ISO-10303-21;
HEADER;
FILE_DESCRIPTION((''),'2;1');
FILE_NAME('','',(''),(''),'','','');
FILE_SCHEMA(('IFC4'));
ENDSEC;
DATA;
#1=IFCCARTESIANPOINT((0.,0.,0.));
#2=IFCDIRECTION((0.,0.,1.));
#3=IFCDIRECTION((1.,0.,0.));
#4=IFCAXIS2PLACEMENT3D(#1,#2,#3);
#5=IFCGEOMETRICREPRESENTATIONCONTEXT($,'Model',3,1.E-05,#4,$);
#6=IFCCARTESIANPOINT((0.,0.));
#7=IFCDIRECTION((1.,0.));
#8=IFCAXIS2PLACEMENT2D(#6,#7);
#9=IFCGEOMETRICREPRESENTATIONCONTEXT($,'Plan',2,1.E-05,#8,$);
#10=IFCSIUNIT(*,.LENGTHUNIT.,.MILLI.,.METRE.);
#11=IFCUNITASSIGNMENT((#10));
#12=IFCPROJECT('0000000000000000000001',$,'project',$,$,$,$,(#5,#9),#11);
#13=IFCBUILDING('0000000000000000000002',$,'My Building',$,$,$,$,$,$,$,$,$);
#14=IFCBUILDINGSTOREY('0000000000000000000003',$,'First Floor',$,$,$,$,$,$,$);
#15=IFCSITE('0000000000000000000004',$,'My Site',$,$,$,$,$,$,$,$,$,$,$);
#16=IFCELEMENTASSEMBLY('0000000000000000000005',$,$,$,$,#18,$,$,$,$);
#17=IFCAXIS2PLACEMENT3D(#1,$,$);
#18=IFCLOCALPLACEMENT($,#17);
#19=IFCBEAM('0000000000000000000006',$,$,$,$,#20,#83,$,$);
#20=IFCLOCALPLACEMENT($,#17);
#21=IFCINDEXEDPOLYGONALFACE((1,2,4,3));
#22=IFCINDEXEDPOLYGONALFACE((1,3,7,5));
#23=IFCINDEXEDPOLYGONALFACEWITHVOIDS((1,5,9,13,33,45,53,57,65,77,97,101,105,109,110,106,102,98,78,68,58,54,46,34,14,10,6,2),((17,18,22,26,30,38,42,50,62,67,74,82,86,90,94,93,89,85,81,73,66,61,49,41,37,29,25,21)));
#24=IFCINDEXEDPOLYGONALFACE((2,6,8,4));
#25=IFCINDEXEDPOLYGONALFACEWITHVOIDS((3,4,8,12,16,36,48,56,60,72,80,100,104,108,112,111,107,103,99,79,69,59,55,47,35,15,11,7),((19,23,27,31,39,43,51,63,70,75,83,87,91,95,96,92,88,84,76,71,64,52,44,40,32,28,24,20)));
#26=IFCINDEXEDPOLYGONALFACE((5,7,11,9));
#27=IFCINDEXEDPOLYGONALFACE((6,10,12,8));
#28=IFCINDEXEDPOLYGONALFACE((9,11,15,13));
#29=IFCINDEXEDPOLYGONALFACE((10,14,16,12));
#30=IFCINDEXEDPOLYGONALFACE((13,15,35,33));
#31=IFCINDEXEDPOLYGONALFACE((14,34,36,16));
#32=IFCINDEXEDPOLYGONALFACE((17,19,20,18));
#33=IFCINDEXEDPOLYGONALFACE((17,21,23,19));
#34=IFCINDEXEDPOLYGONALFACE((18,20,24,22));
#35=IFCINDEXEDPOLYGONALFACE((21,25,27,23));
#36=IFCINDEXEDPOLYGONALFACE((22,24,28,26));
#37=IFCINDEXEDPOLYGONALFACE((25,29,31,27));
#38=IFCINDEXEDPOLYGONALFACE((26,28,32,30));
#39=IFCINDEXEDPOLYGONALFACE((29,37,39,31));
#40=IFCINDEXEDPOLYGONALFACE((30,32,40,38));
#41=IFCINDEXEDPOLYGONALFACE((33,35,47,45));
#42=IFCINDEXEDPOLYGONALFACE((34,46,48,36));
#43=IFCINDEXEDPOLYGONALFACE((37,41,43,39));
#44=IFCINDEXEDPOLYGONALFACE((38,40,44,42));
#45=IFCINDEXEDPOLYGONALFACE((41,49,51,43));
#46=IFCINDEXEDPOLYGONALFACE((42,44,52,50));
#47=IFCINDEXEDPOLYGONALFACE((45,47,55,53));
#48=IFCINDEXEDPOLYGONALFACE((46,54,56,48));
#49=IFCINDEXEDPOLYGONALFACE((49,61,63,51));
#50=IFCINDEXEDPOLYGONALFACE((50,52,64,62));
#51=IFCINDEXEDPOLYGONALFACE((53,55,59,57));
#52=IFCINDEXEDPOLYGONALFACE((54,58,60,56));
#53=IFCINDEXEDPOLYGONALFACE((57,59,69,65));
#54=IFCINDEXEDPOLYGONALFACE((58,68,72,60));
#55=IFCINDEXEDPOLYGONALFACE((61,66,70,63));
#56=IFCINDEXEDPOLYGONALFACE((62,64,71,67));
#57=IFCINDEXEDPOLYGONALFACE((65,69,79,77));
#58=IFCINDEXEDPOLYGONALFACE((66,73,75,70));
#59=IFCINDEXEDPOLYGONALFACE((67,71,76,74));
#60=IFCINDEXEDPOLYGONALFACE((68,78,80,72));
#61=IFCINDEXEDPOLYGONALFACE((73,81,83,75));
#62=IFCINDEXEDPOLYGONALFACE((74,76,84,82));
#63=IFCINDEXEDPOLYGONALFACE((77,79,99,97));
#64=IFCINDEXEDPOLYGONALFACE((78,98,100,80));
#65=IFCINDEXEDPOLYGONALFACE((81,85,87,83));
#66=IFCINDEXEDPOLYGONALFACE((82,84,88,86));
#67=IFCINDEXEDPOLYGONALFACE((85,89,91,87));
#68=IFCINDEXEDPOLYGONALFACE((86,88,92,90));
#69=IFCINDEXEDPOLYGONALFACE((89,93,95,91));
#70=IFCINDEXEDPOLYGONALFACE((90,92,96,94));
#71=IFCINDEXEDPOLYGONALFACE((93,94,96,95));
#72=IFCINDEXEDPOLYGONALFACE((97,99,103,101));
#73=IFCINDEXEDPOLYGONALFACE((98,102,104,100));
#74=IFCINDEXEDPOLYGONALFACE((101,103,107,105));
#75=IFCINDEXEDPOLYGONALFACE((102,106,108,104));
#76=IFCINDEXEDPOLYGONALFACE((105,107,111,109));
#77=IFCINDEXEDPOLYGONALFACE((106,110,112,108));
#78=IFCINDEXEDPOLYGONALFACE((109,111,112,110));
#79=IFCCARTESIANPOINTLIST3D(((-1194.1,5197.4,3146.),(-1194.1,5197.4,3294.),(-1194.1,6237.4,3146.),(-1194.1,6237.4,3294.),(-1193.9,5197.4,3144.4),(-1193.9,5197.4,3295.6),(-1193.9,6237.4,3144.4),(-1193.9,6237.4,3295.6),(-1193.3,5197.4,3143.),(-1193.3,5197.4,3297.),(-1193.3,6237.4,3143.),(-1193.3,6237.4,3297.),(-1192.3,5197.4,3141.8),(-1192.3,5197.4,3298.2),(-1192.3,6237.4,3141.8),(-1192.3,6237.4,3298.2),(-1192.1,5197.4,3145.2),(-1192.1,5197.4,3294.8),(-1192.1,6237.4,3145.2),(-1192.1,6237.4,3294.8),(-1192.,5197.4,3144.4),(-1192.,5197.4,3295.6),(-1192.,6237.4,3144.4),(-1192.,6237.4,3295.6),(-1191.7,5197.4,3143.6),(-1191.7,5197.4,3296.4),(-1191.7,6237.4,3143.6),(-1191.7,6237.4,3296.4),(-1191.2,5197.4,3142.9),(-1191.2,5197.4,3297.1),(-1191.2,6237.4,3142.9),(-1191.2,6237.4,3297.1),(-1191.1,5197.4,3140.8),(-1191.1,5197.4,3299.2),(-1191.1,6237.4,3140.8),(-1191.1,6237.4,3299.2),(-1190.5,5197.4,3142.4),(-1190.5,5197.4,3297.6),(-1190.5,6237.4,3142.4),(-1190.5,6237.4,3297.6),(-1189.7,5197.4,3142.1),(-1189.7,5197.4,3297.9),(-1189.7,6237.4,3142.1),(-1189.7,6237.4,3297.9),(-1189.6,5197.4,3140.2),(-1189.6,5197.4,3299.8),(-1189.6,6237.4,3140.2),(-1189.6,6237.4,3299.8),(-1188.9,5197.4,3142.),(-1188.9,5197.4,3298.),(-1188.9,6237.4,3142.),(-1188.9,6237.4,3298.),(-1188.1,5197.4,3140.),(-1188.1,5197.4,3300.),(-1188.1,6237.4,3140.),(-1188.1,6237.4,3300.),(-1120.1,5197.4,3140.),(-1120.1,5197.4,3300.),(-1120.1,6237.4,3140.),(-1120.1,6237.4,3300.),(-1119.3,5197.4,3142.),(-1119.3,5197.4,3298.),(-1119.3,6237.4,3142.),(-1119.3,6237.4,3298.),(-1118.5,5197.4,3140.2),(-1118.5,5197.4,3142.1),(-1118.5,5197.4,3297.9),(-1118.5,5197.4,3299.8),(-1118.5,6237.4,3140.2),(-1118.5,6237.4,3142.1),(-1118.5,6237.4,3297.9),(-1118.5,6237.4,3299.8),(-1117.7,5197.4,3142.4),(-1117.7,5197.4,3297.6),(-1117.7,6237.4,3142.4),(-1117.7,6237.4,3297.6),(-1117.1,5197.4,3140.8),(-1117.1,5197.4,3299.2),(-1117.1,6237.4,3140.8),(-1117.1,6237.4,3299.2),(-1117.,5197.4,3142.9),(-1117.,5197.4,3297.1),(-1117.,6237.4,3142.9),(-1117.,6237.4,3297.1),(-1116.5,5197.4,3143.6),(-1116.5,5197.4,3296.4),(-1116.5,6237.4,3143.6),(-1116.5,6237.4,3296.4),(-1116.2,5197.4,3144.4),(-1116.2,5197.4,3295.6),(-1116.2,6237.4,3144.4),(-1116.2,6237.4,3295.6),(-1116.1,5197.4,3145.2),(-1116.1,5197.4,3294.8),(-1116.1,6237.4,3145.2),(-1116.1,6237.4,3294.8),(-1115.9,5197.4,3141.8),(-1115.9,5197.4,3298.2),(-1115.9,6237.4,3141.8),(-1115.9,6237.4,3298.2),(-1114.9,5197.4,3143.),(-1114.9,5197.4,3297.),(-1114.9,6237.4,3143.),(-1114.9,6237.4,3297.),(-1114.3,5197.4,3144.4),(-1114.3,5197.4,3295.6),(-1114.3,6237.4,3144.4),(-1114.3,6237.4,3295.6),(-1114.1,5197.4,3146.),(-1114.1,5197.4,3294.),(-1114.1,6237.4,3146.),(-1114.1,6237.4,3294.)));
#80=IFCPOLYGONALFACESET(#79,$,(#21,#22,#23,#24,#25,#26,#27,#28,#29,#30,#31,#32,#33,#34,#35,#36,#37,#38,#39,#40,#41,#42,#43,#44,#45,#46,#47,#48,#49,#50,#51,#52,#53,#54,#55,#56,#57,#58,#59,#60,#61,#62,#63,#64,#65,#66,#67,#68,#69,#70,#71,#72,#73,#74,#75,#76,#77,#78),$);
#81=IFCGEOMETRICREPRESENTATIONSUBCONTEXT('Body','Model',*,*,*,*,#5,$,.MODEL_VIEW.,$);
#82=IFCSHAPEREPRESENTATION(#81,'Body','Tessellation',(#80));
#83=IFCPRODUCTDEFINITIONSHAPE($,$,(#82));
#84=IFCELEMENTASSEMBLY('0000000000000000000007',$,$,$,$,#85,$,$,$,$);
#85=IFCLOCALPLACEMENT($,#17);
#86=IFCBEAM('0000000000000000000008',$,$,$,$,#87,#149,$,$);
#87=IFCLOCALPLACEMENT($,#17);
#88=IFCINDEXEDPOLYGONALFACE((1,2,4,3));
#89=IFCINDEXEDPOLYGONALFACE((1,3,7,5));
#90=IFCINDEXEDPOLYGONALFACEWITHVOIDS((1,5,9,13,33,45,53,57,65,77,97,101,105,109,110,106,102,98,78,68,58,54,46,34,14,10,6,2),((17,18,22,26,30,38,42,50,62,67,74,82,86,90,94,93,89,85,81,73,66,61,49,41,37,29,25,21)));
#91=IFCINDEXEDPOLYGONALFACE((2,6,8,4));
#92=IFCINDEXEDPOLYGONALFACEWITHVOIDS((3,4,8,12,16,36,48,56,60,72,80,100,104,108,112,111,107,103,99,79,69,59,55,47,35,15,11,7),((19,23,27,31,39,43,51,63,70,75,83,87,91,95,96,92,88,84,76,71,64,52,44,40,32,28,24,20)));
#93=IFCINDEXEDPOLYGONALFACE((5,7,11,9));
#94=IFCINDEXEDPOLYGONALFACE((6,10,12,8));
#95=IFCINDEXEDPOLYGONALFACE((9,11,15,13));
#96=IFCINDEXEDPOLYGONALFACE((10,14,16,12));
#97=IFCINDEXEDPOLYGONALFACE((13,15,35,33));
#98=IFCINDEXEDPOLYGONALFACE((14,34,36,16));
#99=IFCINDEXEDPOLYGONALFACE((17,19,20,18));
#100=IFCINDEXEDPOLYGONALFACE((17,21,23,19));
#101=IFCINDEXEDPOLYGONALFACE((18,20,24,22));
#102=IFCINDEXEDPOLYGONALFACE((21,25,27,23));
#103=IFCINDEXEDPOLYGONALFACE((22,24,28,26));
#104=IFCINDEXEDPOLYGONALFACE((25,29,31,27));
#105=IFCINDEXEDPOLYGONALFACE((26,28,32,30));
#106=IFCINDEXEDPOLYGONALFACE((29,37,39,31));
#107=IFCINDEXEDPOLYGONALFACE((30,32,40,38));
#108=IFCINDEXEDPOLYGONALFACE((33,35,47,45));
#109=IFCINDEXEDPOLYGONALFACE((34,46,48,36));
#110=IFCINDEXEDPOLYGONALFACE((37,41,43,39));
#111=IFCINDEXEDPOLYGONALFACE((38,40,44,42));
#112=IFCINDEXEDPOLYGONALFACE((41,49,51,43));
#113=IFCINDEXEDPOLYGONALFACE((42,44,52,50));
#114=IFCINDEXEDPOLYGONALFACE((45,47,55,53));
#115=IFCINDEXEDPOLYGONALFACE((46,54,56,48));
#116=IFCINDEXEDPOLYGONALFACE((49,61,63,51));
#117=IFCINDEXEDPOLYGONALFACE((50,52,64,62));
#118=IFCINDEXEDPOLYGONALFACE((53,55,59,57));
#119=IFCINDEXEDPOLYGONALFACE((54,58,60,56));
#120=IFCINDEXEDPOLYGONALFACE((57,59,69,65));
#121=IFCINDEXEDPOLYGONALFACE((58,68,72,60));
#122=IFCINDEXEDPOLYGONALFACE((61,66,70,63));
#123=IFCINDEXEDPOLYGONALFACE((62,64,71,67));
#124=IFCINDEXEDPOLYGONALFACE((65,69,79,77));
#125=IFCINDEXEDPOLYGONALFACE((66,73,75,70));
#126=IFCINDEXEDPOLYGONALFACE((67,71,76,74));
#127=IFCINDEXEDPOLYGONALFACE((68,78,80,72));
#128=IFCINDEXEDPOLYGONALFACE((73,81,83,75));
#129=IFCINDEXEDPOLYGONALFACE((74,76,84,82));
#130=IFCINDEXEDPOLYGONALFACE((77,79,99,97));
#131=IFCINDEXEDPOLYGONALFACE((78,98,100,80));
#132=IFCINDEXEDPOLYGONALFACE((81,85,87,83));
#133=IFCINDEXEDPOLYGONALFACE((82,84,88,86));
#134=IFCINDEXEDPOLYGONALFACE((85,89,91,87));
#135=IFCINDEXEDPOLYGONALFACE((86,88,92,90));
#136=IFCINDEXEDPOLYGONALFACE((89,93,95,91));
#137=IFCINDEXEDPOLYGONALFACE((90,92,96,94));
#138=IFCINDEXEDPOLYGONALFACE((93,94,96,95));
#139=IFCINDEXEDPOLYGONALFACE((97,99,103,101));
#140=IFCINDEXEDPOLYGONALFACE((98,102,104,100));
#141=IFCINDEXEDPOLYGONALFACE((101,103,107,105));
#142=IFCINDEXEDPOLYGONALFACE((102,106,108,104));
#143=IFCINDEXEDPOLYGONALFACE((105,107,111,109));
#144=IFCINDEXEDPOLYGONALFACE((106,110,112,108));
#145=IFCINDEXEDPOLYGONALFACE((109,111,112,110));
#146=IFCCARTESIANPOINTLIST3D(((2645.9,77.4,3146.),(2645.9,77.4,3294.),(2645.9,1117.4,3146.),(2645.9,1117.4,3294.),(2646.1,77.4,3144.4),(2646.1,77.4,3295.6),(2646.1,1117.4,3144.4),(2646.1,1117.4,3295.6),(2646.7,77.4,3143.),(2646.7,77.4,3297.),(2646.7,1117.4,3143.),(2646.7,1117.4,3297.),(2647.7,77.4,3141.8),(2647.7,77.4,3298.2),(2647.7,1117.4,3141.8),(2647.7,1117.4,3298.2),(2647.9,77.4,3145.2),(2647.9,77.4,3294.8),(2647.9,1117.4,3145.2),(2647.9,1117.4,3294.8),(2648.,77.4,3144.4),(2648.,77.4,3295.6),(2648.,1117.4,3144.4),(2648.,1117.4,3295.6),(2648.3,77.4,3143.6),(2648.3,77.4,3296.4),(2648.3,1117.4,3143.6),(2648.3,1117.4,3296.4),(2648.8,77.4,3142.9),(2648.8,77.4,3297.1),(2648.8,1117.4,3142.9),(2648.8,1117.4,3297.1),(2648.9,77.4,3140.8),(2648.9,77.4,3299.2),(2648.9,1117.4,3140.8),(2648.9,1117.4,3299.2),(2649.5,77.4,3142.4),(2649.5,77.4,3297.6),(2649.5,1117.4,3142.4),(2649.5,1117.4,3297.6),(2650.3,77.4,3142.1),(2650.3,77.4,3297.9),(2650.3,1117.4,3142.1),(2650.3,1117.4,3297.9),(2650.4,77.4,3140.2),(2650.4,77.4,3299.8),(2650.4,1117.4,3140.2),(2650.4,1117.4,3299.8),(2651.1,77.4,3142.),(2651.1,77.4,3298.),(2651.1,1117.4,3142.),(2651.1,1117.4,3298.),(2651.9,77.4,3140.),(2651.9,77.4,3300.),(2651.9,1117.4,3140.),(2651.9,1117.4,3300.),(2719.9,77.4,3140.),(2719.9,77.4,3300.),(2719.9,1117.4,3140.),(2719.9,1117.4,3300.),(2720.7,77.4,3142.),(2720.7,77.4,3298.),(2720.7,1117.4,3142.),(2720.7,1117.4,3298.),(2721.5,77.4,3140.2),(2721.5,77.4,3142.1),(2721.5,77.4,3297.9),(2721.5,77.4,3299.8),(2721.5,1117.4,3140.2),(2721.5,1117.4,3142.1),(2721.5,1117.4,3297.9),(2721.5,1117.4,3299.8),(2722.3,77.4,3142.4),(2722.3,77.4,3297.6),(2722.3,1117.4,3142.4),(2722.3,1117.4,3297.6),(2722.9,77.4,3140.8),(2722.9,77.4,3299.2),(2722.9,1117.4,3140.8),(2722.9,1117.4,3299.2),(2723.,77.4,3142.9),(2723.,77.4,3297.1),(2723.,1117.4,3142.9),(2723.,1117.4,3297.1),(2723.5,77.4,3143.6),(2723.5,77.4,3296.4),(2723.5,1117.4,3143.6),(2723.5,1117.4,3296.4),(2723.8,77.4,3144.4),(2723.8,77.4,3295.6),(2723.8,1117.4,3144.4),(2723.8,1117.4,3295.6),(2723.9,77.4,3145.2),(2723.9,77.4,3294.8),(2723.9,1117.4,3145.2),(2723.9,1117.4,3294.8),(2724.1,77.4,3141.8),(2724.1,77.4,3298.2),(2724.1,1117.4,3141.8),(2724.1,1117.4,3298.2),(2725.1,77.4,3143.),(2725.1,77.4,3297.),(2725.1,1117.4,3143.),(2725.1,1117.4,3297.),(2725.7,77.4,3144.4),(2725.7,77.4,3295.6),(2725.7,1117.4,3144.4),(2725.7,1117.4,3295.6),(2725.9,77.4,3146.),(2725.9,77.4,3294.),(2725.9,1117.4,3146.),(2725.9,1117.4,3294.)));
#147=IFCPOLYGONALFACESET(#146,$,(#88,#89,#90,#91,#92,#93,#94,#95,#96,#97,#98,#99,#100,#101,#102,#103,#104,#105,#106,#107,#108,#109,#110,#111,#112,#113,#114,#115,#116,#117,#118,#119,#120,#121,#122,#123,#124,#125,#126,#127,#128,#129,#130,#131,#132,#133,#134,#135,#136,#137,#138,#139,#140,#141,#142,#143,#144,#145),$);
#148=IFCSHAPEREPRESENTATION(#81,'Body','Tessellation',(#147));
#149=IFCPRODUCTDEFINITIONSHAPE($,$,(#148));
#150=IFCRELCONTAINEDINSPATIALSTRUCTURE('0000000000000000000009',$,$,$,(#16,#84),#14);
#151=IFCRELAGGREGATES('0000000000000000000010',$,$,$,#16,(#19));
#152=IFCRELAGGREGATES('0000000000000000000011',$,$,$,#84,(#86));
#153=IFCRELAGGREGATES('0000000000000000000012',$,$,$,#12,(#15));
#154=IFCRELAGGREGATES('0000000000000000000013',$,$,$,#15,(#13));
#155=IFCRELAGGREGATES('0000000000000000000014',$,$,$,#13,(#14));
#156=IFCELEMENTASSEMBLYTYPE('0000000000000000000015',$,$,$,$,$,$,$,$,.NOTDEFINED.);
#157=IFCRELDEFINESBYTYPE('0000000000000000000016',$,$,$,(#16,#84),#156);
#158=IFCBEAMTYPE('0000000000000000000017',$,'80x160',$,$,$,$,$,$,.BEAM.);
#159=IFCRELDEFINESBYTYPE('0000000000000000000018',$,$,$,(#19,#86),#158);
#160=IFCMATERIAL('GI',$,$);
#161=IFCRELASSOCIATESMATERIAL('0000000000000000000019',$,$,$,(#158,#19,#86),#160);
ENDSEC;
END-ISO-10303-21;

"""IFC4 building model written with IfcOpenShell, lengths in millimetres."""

from ifc_helpers import new_model, si_unit, frame, origin_with_axes, origin_2d_with_axis, place, context, subcontext, project, spatial, hollow_rectangle, extrude, material, material_profile, profile_set, profile_usage, type_object, element, aggregate, save


model = new_model("IFC4")

# Units and contexts
model_context = context("Model", 3, precision=1e-05, world=origin_with_axes())
plan_context = context("Plan", 2, precision=1e-05, world=origin_2d_with_axis())
body_context = subcontext(model_context, "Body", "Model", "MODEL_VIEW")
ifc_project = project(units=[si_unit("LENGTHUNIT", "METRE", prefix="MILLI")], contexts=[model_context, plan_context])

# Site, building, storey
site = spatial("IfcSite", under=ifc_project, Name="My Site")
building = spatial("IfcBuilding", under=site, Name="My Building")
storey = spatial("IfcBuildingStorey", under=building, Name="First Floor")

# Element assemblies, beams
element_assembly_type = type_object("IfcElementAssemblyType", PredefinedType="NOTDEFINED")
ifc_material = material(Name="GI")
ifc_material_profile = material_profile(ifc_material, hollow_rectangle(XDim=80.0, YDim=160.0, WallThickness=2.0, InnerFilletRadius=3.2, OuterFilletRadius=6.0))
ifc_profile_set = profile_set([ifc_material_profile], Name="80x160 GI Rectangular Hollow")
beam_type = type_object("IfcBeamType", Name="80x160", PredefinedType="BEAM", material=ifc_profile_set)
assembly_1_placement = place(None, frame((-1154.1, 5117.4, 3220.0), z_axis=(0.0, 1.0, 0.0), x_axis=(1.0, 0.0, 0.0)))
assembly_1 = element("IfcElementAssembly", 1, at=assembly_1_placement, inside=storey, type_object=element_assembly_type)
ifc_profile_usage_1 = profile_usage(ifc_profile_set)
beam_1_placement = place(assembly_1_placement, frame((0.0, 0.0, 80.0), z_axis=(0.0, 0.0, 1.0), x_axis=(1.0, 0.0, 0.0)))
beam_1 = element("IfcBeam", 2, at=beam_1_placement, type_object=beam_type, material=ifc_profile_usage_1, context=body_context, shape_type="SweptSolid", body=[
    extrude(hollow_rectangle(XDim=80.0, YDim=160.0, WallThickness=2.0, InnerFilletRadius=3.2, OuterFilletRadius=6.0), origin_with_axes(), (0.0, 0.0, 1.0), 1040.0),
])
aggregate(assembly_1, [beam_1])
assembly_2_placement = place(None, frame((2685.9, -2.6, 3220.0), z_axis=(0.0, 1.0, 0.0), x_axis=(1.0, 0.0, 0.0)))
assembly_2 = element("IfcElementAssembly", 3, at=assembly_2_placement, inside=storey, type_object=element_assembly_type)
ifc_profile_usage_2 = profile_usage(ifc_profile_set)
beam_2_placement = place(assembly_2_placement, frame((0.0, 0.0, 80.0), z_axis=(0.0, 0.0, 1.0), x_axis=(1.0, 0.0, 0.0)))
beam_2 = element("IfcBeam", 4, at=beam_2_placement, type_object=beam_type, material=ifc_profile_usage_2, context=body_context, shape_type="SweptSolid", body=[
    extrude(hollow_rectangle(XDim=80.0, YDim=160.0, WallThickness=2.0, InnerFilletRadius=3.2, OuterFilletRadius=6.0), origin_with_axes(), (0.0, 0.0, 1.0), 1040.0),
])
aggregate(assembly_2, [beam_2])

save(model, "model.ifc")
